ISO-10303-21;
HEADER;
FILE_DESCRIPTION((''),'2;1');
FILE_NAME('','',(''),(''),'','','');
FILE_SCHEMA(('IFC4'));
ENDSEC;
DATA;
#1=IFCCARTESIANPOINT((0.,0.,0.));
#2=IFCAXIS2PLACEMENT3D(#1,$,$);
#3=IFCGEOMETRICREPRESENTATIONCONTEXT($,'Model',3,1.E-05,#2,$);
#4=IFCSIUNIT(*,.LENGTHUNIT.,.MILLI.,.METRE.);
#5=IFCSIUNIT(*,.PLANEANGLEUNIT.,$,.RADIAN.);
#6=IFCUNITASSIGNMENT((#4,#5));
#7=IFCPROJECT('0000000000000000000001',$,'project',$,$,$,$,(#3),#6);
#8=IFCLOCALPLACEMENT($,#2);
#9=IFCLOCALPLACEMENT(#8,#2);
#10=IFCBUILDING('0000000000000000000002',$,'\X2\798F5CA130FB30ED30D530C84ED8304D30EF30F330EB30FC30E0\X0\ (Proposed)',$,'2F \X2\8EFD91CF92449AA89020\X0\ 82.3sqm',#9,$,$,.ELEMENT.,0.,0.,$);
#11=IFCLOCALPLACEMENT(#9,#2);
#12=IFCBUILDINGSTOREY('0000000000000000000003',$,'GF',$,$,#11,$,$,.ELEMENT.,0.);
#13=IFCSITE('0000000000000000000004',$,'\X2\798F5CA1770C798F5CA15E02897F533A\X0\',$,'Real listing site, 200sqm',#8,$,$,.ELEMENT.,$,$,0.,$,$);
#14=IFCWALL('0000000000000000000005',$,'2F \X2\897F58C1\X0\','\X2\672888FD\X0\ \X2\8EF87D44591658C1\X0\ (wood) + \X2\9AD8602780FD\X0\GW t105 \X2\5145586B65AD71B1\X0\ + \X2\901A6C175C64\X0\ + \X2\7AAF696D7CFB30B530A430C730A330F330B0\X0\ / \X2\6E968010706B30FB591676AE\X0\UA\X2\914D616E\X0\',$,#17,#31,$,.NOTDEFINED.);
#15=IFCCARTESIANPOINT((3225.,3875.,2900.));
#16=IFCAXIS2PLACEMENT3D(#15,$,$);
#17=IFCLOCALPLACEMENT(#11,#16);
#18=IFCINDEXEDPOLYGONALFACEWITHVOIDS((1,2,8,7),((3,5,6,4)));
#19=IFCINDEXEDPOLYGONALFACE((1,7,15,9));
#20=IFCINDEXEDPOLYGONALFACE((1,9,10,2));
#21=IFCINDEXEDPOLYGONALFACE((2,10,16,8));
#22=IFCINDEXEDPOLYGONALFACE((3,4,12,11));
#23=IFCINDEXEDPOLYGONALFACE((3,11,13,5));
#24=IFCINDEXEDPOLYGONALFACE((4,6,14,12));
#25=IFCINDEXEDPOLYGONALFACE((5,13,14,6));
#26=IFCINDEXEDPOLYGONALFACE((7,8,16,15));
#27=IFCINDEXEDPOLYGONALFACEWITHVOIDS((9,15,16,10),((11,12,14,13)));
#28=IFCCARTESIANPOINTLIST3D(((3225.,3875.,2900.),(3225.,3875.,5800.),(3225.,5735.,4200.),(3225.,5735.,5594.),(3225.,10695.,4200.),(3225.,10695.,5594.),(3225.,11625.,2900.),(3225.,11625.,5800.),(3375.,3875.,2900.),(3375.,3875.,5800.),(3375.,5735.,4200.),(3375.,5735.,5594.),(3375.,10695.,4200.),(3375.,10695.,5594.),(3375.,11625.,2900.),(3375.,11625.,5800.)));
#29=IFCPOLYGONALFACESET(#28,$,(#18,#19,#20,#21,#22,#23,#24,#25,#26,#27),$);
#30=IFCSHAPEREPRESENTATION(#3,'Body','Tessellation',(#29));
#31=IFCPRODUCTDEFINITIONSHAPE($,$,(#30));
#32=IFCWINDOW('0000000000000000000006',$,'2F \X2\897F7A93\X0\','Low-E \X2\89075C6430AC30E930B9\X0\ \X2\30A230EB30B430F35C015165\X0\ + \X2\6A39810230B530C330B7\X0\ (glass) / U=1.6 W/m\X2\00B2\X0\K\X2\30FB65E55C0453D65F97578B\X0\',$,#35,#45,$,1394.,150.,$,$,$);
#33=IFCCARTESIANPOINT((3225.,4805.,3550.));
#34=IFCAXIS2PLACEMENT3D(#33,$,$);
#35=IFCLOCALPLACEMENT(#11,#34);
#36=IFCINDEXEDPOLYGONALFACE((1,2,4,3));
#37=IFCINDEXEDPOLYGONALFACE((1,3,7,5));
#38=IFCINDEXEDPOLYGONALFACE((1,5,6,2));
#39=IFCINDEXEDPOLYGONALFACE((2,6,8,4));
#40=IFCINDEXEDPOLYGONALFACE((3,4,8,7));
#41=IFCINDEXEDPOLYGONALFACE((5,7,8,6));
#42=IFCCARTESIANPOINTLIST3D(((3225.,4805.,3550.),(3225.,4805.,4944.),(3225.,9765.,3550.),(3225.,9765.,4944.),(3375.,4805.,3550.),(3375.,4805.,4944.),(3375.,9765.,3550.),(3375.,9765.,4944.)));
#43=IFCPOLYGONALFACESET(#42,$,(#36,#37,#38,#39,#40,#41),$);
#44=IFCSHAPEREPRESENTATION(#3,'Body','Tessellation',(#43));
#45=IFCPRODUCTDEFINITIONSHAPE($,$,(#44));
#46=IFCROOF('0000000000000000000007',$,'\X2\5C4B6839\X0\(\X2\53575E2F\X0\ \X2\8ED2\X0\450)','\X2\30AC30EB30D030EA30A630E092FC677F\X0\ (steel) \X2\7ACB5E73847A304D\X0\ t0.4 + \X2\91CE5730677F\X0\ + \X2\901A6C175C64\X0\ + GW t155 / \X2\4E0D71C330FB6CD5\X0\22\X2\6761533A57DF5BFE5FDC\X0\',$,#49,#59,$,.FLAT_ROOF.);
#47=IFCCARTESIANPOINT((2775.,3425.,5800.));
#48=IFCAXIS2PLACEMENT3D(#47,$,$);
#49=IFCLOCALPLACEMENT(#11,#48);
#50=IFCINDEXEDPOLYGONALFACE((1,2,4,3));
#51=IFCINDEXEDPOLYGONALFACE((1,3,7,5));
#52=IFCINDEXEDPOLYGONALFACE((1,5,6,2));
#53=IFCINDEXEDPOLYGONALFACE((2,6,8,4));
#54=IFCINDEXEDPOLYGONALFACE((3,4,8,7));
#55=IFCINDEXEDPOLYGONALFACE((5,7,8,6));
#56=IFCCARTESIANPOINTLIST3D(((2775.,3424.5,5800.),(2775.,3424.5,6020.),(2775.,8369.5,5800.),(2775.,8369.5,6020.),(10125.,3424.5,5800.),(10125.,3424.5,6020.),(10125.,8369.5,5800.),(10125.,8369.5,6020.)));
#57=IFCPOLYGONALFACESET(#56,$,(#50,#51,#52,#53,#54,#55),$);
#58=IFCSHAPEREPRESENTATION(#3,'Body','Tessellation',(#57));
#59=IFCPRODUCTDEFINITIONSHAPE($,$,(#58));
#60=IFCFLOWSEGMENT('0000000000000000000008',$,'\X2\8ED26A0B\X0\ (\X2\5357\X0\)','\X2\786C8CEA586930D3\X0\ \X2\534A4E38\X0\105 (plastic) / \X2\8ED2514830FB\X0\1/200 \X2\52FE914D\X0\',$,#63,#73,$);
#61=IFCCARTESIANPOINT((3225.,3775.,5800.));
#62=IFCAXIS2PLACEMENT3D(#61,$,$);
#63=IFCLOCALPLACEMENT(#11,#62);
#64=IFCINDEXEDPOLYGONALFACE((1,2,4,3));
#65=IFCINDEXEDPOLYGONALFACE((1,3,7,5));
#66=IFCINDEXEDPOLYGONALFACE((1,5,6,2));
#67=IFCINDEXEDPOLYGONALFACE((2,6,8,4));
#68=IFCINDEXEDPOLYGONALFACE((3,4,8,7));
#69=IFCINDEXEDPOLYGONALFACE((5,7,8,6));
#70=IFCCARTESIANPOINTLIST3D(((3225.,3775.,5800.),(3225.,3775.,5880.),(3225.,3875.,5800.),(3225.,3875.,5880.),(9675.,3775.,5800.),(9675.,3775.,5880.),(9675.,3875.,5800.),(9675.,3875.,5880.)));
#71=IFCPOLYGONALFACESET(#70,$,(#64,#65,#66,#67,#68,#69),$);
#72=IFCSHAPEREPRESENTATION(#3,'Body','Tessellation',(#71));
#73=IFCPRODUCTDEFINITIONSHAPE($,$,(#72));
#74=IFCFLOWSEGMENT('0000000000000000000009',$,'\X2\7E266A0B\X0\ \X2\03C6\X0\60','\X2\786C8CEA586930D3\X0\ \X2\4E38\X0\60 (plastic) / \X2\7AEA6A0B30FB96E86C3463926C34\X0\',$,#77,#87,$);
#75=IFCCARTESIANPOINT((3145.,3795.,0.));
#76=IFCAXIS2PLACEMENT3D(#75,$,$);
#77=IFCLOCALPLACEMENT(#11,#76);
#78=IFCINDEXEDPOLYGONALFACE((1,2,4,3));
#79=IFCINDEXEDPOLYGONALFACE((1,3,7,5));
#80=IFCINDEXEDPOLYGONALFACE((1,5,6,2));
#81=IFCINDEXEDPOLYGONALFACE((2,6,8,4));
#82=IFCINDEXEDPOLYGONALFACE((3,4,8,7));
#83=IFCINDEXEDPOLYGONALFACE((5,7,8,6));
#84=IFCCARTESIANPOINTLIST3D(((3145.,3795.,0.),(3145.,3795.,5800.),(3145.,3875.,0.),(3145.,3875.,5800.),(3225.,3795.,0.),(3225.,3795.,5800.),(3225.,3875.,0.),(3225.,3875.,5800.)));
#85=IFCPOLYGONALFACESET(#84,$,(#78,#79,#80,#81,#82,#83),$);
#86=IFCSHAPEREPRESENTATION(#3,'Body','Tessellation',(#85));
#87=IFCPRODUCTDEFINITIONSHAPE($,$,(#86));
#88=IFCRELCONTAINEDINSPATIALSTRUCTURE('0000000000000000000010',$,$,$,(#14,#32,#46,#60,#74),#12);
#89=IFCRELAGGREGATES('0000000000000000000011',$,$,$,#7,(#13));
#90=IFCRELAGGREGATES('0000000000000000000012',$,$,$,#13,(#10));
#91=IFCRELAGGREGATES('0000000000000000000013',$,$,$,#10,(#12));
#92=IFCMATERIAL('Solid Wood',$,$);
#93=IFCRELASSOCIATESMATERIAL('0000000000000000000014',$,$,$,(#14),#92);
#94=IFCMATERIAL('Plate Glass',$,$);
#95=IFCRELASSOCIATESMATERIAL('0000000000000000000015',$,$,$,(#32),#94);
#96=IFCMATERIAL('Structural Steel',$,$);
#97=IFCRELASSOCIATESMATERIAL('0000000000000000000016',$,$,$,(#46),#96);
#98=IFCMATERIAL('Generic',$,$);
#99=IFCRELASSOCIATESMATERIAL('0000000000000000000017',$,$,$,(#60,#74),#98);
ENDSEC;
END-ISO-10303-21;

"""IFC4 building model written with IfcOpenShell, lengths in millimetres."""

from ifc_helpers import new_model, si_unit, frame, frame_2d, origin, place, context, project, spatial, rectangle, extrude, material, element, fill, save


model = new_model("IFC4")

# Units and contexts
model_context = context("Model", 3, precision=1e-05, world=origin())
ifc_project = project(units=[si_unit("LENGTHUNIT", "METRE", prefix="MILLI"), si_unit("PLANEANGLEUNIT", "RADIAN")], contexts=[model_context])

# Site, building, storey
site_placement = place(None, origin())
site = spatial("IfcSite", under=ifc_project, at=site_placement, Name="福岡県福岡市西区", ObjectType="Real listing site, 200sqm", CompositionType="ELEMENT", RefElevation=0.0)
building_placement = place(site_placement, origin())
building = spatial("IfcBuilding", under=site, at=building_placement, Name="福岡・ロフト付きワンルーム (Proposed)", ObjectType="2F 軽量鉄骨造 82.3sqm", CompositionType="ELEMENT", ElevationOfRefHeight=0.0, ElevationOfTerrain=0.0)
storey_placement = place(building_placement, origin())
storey = spatial("IfcBuildingStorey", under=building, at=storey_placement, Name="GF", CompositionType="ELEMENT", Elevation=0.0)

# Shared definitions
ifc_material_1 = material(Name="Solid Wood")

# Shared definitions
ifc_material_2 = material(Name="Plate Glass")

# Wall, opening, window
wall_1_placement = place(storey_placement, frame((3225.0, 3875.0, 2900.0)))
wall_1 = element("IfcWall", 1, at=wall_1_placement, inside=storey, material=ifc_material_1, Name="2F 西壁", Description="木製 軸組外壁 (wood) + 高性能GW t105 充填断熱 + 通気層 + 窯業系サイディング / 準耐火・外皮UA配慮", PredefinedType="NOTDEFINED", context=model_context, shape_type="SweptSolid", body=[
    extrude(rectangle(XDim=150.0, YDim=7750.0, at=frame_2d((75.0, 3875.0))), frame((3225.0, 3875.0, 2900.0)), (0.0, 0.0, 1.0), 2900.0),
])
opening_1_placement = place(storey_placement, frame((3225.0, 4805.0, 3550.0)))
opening_1 = element("IfcOpeningElement", 2, at=opening_1_placement, cuts=wall_1, PredefinedType="NOTDEFINED", context=model_context, shape_type="SweptSolid", body=[
    extrude(rectangle(XDim=150.0, YDim=4960.0, at=frame_2d((75.0, 2480.0))), frame((3225.0, 4805.0, 3550.0)), (0.0, 0.0, 1.0), 1394.0),
])
window_1_placement = place(storey_placement, frame((3225.0, 4805.0, 3550.0)))
window_1 = element("IfcWindow", 3, at=window_1_placement, inside=storey, material=ifc_material_2, Name="2F 西窓", Description="Low-E 複層ガラス アルゴン封入 + 樹脂サッシ (glass) / U=1.6 W/m²K・日射取得型", OverallHeight=1394.0, OverallWidth=150.0, context=model_context, shape_type="SweptSolid", body=[
    extrude(rectangle(XDim=150.0, YDim=4960.0, at=frame_2d((75.0, 2480.0))), frame((3225.0, 4805.0, 3550.0)), (0.0, 0.0, 1.0), 1394.0),
])
fill(opening_1, window_1)

# Roof
ifc_material_3 = material(Name="Structural Steel")
for number, where, name in (
    (4, (2775.0, 3425.0, 5800.0), "屋根(南帯 軒450)"),
):
    element("IfcRoof", number, at=place(storey_placement, frame(where)), inside=storey, material=ifc_material_3, Name=name, Description="ガルバリウム鋼板 (steel) 立平葺き t0.4 + 野地板 + 通気層 + GW t155 / 不燃・法22条区域対応", PredefinedType="FLAT_ROOF", context=model_context, shape_type="SweptSolid", body=[
        extrude(rectangle(XDim=7350.0, YDim=4945.0, at=frame_2d((3675.0, 2472.0))), frame((2775.0, 3425.0, 5800.0)), (0.0, 0.0, 1.0), 220.0),
    ])

# Flow segments
ifc_material_4 = material(Name="Generic")
flow_segment_1_placement = place(storey_placement, frame((3225.0, 3775.0, 5800.0)))
element("IfcFlowSegment", 5, at=flow_segment_1_placement, inside=storey, material=ifc_material_4, Name="軒樋 (南)", Description="硬質塩ビ 半丸105 (plastic) / 軒先・1/200 勾配", context=model_context, shape_type="SweptSolid", body=[
    extrude(rectangle(XDim=6450.0, YDim=100.0, at=frame_2d((3225.0, 50.0))), frame((3225.0, 3775.0, 5800.0)), (0.0, 0.0, 1.0), 80.0),
])
flow_segment_2_placement = place(storey_placement, frame((3145.0, 3795.0, 0.0)))
element("IfcFlowSegment", 6, at=flow_segment_2_placement, inside=storey, material=ifc_material_4, Name="縦樋 φ60", Description="硬質塩ビ 丸60 (plastic) / 竪樋・雨水排水", context=model_context, shape_type="SweptSolid", body=[
    extrude(rectangle(XDim=80.0, YDim=80.0, at=frame_2d((40.0, 40.0))), frame((3145.0, 3795.0, 0.0)), (0.0, 0.0, 1.0), 5800.0),
])

save(model, "model.ifc")
